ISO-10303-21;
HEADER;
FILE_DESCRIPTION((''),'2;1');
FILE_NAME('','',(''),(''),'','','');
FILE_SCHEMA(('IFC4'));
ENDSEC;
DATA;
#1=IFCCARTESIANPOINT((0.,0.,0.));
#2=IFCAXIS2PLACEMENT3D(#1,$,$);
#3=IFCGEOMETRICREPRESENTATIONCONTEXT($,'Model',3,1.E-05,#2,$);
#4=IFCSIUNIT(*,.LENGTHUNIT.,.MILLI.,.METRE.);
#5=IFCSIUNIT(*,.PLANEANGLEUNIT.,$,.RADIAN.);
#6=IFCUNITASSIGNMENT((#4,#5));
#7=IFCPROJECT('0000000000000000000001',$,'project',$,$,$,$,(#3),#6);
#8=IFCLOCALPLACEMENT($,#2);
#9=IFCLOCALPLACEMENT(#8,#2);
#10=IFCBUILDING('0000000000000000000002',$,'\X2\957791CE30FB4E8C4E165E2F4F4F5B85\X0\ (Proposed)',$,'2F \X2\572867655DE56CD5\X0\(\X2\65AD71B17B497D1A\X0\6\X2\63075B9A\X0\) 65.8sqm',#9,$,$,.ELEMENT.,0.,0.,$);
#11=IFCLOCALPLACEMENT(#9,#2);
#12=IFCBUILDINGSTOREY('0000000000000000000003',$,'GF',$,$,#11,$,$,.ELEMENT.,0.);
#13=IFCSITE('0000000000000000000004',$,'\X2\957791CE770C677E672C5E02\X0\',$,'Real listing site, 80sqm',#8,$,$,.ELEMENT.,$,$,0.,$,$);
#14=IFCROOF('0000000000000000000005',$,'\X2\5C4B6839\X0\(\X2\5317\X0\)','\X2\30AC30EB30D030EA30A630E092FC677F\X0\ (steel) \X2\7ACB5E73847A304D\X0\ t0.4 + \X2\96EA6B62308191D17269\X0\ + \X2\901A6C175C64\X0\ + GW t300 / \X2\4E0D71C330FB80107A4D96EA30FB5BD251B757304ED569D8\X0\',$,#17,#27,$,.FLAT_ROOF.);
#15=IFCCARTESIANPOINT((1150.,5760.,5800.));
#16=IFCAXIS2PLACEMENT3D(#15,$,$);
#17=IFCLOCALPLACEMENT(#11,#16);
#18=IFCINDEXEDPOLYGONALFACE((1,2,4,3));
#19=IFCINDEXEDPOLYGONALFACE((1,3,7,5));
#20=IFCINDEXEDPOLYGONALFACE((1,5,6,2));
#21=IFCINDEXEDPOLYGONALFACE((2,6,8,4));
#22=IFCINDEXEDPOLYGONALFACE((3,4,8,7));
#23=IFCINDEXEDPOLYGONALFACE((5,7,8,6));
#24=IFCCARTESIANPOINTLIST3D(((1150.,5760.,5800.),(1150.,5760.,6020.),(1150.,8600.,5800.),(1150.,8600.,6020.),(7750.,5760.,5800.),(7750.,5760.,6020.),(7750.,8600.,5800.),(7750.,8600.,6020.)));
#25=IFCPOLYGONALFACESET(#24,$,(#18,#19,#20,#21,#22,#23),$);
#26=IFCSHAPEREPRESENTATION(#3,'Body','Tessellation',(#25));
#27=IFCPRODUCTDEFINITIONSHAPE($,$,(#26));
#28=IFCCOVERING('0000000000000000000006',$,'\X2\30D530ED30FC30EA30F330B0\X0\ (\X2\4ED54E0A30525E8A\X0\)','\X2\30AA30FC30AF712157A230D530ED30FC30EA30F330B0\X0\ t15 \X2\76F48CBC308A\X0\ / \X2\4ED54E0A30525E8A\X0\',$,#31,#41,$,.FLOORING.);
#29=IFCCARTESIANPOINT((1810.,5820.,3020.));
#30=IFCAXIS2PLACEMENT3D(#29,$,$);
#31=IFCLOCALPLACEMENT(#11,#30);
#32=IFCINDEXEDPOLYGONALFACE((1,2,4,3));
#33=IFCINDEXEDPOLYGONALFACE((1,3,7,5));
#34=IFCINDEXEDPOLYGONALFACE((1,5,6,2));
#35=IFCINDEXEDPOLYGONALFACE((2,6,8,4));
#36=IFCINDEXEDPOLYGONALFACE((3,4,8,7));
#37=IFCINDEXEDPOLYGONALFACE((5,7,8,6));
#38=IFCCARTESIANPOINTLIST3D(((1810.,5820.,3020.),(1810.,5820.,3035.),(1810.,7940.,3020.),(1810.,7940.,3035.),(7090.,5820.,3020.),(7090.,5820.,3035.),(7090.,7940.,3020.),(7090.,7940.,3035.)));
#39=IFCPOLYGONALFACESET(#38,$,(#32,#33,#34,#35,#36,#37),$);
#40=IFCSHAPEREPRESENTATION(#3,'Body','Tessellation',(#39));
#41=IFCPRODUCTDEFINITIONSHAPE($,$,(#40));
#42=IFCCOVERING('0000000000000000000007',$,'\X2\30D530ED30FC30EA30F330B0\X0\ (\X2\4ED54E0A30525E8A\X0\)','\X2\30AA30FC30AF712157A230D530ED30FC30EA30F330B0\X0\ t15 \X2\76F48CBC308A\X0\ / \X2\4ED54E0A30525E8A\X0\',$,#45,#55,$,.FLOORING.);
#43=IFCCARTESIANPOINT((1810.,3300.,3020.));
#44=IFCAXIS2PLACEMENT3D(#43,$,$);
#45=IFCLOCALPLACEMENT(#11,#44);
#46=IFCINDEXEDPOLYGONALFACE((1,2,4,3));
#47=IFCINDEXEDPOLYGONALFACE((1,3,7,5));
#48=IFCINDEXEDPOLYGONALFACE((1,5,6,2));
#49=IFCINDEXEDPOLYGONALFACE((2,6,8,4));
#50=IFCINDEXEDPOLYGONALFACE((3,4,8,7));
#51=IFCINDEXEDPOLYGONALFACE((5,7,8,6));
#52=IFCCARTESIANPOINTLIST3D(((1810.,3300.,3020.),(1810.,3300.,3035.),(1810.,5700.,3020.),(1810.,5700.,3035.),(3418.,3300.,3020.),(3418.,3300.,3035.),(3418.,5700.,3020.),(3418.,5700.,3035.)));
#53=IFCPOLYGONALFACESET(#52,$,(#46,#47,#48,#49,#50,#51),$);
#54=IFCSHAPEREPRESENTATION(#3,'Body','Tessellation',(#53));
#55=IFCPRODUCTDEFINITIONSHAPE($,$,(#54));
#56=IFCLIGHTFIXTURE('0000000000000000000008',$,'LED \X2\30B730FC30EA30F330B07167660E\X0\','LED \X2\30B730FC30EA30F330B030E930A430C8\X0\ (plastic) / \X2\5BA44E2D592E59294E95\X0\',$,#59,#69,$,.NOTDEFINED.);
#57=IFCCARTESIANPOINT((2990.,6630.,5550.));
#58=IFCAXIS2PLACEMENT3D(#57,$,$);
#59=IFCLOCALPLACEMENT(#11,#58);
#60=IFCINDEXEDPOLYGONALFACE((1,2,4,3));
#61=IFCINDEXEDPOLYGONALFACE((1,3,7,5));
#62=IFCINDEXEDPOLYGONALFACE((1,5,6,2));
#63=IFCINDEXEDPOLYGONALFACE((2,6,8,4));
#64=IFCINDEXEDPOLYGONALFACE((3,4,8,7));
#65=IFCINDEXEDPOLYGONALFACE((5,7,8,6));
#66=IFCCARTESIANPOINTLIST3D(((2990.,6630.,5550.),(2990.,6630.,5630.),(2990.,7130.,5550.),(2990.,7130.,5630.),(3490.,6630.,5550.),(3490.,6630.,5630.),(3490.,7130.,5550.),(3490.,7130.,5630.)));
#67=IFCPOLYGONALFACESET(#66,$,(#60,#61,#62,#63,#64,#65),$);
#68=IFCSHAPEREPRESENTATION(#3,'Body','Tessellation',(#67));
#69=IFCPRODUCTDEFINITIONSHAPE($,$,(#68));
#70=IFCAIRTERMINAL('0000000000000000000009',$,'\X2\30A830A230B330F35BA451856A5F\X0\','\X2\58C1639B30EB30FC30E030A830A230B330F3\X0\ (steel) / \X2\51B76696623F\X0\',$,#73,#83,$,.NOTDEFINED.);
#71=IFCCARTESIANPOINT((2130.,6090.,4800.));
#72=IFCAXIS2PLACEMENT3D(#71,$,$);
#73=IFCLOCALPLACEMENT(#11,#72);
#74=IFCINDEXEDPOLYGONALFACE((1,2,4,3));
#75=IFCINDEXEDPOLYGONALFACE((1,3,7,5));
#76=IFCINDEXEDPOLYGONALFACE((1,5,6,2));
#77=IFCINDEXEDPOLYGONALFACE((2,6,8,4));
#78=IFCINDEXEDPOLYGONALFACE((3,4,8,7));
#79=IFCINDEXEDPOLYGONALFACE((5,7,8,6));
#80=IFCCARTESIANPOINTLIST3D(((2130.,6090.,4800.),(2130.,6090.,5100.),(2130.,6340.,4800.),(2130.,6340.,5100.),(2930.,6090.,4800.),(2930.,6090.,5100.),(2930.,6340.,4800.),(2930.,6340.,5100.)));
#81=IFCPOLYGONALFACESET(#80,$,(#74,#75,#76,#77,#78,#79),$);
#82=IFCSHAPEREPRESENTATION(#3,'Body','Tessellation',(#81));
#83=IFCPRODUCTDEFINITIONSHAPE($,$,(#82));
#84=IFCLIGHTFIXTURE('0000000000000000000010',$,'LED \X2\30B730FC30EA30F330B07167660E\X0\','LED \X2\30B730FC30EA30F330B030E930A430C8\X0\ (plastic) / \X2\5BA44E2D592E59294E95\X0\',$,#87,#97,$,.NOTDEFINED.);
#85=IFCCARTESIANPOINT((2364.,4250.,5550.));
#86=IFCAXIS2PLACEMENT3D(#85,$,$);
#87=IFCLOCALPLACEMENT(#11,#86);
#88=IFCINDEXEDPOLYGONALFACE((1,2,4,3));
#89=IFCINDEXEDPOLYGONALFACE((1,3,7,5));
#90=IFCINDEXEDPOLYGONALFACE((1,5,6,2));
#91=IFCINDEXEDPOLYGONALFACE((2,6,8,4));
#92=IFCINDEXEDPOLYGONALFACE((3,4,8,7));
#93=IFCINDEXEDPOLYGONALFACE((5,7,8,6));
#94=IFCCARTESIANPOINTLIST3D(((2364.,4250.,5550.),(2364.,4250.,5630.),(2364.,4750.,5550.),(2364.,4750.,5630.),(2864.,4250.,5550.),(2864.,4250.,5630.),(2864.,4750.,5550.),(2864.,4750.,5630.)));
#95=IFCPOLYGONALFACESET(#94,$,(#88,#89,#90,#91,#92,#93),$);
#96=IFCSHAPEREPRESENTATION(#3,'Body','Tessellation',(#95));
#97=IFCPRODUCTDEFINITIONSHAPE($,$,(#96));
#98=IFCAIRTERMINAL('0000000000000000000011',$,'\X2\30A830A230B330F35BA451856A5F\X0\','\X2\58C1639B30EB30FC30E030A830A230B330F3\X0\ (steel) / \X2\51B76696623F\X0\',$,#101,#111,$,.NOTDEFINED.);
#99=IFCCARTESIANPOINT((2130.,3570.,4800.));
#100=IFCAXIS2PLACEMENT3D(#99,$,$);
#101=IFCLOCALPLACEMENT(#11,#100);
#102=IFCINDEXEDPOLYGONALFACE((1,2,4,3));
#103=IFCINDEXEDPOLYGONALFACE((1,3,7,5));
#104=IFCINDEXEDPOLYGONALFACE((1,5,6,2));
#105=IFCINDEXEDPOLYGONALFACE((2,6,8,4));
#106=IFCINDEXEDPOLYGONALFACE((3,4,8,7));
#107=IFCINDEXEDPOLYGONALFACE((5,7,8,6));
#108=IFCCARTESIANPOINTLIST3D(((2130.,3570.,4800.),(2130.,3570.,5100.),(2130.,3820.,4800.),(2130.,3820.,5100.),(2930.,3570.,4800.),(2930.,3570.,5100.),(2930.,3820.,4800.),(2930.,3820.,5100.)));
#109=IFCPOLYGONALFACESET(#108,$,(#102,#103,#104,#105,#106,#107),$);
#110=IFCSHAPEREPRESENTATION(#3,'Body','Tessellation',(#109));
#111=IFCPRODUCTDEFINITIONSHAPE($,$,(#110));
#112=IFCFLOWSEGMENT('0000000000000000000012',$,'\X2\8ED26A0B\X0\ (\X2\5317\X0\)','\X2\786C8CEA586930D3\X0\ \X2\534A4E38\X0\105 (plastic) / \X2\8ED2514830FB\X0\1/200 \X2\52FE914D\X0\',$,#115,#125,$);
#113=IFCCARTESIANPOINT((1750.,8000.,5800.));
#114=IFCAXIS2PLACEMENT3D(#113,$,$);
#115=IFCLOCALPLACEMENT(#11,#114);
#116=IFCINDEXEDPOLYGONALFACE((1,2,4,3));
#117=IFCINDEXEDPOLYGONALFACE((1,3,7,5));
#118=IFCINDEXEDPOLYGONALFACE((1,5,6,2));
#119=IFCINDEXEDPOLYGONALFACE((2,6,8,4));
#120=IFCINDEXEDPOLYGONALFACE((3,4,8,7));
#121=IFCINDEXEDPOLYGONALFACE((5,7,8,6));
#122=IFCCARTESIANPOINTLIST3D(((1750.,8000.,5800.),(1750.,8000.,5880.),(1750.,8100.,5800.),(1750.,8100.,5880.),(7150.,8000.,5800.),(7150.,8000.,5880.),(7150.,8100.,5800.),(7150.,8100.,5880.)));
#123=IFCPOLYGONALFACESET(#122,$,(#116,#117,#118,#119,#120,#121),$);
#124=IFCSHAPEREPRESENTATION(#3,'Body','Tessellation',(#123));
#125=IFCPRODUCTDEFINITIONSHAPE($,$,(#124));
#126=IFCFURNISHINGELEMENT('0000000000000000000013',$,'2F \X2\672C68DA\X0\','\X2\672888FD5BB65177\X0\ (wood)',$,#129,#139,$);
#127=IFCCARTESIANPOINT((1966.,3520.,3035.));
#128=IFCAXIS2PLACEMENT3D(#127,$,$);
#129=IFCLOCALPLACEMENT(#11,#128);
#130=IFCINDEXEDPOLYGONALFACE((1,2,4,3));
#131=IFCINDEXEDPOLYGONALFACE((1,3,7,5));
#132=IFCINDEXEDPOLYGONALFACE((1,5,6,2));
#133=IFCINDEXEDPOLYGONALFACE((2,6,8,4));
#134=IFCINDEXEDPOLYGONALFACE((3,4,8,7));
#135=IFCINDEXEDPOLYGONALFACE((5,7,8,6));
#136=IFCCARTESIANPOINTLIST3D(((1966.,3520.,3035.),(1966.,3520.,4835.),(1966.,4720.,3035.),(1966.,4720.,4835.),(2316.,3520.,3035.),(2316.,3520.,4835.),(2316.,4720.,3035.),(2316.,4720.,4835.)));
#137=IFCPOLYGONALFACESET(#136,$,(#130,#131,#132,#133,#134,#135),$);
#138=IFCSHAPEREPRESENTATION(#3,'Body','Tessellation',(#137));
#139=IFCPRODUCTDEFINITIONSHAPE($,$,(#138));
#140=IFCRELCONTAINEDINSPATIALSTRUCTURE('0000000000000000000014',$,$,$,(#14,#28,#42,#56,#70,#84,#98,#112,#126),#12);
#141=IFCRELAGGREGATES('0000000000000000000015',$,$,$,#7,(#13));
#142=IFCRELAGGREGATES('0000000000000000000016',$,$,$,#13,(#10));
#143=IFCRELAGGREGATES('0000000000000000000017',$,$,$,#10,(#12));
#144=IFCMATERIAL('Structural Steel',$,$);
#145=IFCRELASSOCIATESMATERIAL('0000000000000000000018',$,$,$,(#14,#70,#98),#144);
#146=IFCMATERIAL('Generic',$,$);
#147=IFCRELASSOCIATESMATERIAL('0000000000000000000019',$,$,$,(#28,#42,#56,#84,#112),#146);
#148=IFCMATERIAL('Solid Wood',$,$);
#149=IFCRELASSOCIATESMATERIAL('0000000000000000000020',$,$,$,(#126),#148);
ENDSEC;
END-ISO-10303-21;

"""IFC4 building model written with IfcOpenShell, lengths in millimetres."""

from ifc_helpers import new_model, si_unit, frame, frame_2d, origin, place, context, project, spatial, rectangle, extrude, material, element, save


model = new_model("IFC4")

# Units and contexts
model_context = context("Model", 3, precision=1e-05, world=origin())
ifc_project = project(units=[si_unit("LENGTHUNIT", "METRE", prefix="MILLI"), si_unit("PLANEANGLEUNIT", "RADIAN")], contexts=[model_context])

# Site, building, storey
site_placement = place(None, origin())
site = spatial("IfcSite", under=ifc_project, at=site_placement, Name="長野県松本市", ObjectType="Real listing site, 80sqm", CompositionType="ELEMENT", RefElevation=0.0)
building_placement = place(site_placement, origin())
building = spatial("IfcBuilding", under=site, at=building_placement, Name="長野・二世帯住宅 (Proposed)", ObjectType="2F 在来工法(断熱等級6指定) 65.8sqm", CompositionType="ELEMENT", ElevationOfRefHeight=0.0, ElevationOfTerrain=0.0)
storey_placement = place(building_placement, origin())
storey = spatial("IfcBuildingStorey", under=building, at=storey_placement, Name="GF", CompositionType="ELEMENT", Elevation=0.0)

# Shared definitions
ifc_material_1 = material(Name="Solid Wood")

# Roof
ifc_material_2 = material(Name="Structural Steel")
for number, where, name in (
    (1, (1150.0, 5760.0, 5800.0), "屋根(北)"),
):
    element("IfcRoof", number, at=place(storey_placement, frame(where)), inside=storey, material=ifc_material_2, Name=name, Description="ガルバリウム鋼板 (steel) 立平葺き t0.4 + 雪止め金物 + 通気層 + GW t300 / 不燃・耐積雪・寒冷地仕様", PredefinedType="FLAT_ROOF", context=model_context, shape_type="SweptSolid", body=[
        extrude(rectangle(XDim=6600.0, YDim=2840.0, at=frame_2d((3300.0, 1420.0))), frame((1150.0, 5760.0, 5800.0)), (0.0, 0.0, 1.0), 220.0),
    ])

# Coverings
ifc_material_3 = material(Name="Generic")
covering_1_placement = place(storey_placement, frame((1810.0, 5820.0, 3020.0)))
element("IfcCovering", 2, at=covering_1_placement, inside=storey, material=ifc_material_3, Name="フローリング (仕上げ床)", Description="オーク無垢フローリング t15 直貼り / 仕上げ床", PredefinedType="FLOORING", context=model_context, shape_type="SweptSolid", body=[
    extrude(rectangle(XDim=5280.0, YDim=2120.0, at=frame_2d((2640.0, 1060.0))), frame((1810.0, 5820.0, 3020.0)), (0.0, 0.0, 1.0), 15.0),
])
covering_2_placement = place(storey_placement, frame((1810.0, 3300.0, 3020.0)))
element("IfcCovering", 3, at=covering_2_placement, inside=storey, material=ifc_material_3, Name="フローリング (仕上げ床)", Description="オーク無垢フローリング t15 直貼り / 仕上げ床", PredefinedType="FLOORING", context=model_context, shape_type="SweptSolid", body=[
    extrude(rectangle(XDim=1608.0, YDim=2400.0, at=frame_2d((804.0, 1200.0))), frame((1810.0, 3300.0, 3020.0)), (0.0, 0.0, 1.0), 15.0),
])

# Light fixture
light_fixture_1_placement = place(storey_placement, frame((2990.0, 6630.0, 5550.0)))
element("IfcLightFixture", 4, at=light_fixture_1_placement, inside=storey, material=ifc_material_3, Name="LED シーリング照明", Description="LED シーリングライト (plastic) / 室中央天井", PredefinedType="NOTDEFINED", context=model_context, shape_type="SweptSolid", body=[
    extrude(rectangle(XDim=500.0, YDim=500.0, at=frame_2d((250.0, 250.0))), frame((2990.0, 6630.0, 5550.0)), (0.0, 0.0, 1.0), 80.0),
])

# Air terminal
air_terminal_1_placement = place(storey_placement, frame((2130.0, 6090.0, 4800.0)))
element("IfcAirTerminal", 5, at=air_terminal_1_placement, inside=storey, material=ifc_material_2, Name="エアコン室内機", Description="壁掛ルームエアコン (steel) / 冷暖房", PredefinedType="NOTDEFINED", context=model_context, shape_type="SweptSolid", body=[
    extrude(rectangle(XDim=800.0, YDim=250.0, at=frame_2d((400.0, 125.0))), frame((2130.0, 6090.0, 4800.0)), (0.0, 0.0, 1.0), 300.0),
])

# Light fixture
light_fixture_2_placement = place(storey_placement, frame((2364.0, 4250.0, 5550.0)))
element("IfcLightFixture", 6, at=light_fixture_2_placement, inside=storey, material=ifc_material_3, Name="LED シーリング照明", Description="LED シーリングライト (plastic) / 室中央天井", PredefinedType="NOTDEFINED", context=model_context, shape_type="SweptSolid", body=[
    extrude(rectangle(XDim=500.0, YDim=500.0, at=frame_2d((250.0, 250.0))), frame((2364.0, 4250.0, 5550.0)), (0.0, 0.0, 1.0), 80.0),
])

# Air terminal
air_terminal_2_placement = place(storey_placement, frame((2130.0, 3570.0, 4800.0)))
element("IfcAirTerminal", 7, at=air_terminal_2_placement, inside=storey, material=ifc_material_2, Name="エアコン室内機", Description="壁掛ルームエアコン (steel) / 冷暖房", PredefinedType="NOTDEFINED", context=model_context, shape_type="SweptSolid", body=[
    extrude(rectangle(XDim=800.0, YDim=250.0, at=frame_2d((400.0, 125.0))), frame((2130.0, 3570.0, 4800.0)), (0.0, 0.0, 1.0), 300.0),
])

# Flow segment
flow_segment_placement = place(storey_placement, frame((1750.0, 8000.0, 5800.0)))
element("IfcFlowSegment", 8, at=flow_segment_placement, inside=storey, material=ifc_material_3, Name="軒樋 (北)", Description="硬質塩ビ 半丸105 (plastic) / 軒先・1/200 勾配", context=model_context, shape_type="SweptSolid", body=[
    extrude(rectangle(XDim=5400.0, YDim=100.0, at=frame_2d((2700.0, 50.0))), frame((1750.0, 8000.0, 5800.0)), (0.0, 0.0, 1.0), 80.0),
])

# Furnishing element
furnishing_placement = place(storey_placement, frame((1966.0, 3520.0, 3035.0)))
element("IfcFurnishingElement", 9, at=furnishing_placement, inside=storey, material=ifc_material_1, Name="2F 本棚", Description="木製家具 (wood)", context=model_context, shape_type="SweptSolid", body=[
    extrude(rectangle(XDim=350.0, YDim=1200.0, at=frame_2d((175.0, 600.0))), frame((1966.0, 3520.0, 3035.0)), (0.0, 0.0, 1.0), 1800.0),
])

save(model, "model.ifc")
